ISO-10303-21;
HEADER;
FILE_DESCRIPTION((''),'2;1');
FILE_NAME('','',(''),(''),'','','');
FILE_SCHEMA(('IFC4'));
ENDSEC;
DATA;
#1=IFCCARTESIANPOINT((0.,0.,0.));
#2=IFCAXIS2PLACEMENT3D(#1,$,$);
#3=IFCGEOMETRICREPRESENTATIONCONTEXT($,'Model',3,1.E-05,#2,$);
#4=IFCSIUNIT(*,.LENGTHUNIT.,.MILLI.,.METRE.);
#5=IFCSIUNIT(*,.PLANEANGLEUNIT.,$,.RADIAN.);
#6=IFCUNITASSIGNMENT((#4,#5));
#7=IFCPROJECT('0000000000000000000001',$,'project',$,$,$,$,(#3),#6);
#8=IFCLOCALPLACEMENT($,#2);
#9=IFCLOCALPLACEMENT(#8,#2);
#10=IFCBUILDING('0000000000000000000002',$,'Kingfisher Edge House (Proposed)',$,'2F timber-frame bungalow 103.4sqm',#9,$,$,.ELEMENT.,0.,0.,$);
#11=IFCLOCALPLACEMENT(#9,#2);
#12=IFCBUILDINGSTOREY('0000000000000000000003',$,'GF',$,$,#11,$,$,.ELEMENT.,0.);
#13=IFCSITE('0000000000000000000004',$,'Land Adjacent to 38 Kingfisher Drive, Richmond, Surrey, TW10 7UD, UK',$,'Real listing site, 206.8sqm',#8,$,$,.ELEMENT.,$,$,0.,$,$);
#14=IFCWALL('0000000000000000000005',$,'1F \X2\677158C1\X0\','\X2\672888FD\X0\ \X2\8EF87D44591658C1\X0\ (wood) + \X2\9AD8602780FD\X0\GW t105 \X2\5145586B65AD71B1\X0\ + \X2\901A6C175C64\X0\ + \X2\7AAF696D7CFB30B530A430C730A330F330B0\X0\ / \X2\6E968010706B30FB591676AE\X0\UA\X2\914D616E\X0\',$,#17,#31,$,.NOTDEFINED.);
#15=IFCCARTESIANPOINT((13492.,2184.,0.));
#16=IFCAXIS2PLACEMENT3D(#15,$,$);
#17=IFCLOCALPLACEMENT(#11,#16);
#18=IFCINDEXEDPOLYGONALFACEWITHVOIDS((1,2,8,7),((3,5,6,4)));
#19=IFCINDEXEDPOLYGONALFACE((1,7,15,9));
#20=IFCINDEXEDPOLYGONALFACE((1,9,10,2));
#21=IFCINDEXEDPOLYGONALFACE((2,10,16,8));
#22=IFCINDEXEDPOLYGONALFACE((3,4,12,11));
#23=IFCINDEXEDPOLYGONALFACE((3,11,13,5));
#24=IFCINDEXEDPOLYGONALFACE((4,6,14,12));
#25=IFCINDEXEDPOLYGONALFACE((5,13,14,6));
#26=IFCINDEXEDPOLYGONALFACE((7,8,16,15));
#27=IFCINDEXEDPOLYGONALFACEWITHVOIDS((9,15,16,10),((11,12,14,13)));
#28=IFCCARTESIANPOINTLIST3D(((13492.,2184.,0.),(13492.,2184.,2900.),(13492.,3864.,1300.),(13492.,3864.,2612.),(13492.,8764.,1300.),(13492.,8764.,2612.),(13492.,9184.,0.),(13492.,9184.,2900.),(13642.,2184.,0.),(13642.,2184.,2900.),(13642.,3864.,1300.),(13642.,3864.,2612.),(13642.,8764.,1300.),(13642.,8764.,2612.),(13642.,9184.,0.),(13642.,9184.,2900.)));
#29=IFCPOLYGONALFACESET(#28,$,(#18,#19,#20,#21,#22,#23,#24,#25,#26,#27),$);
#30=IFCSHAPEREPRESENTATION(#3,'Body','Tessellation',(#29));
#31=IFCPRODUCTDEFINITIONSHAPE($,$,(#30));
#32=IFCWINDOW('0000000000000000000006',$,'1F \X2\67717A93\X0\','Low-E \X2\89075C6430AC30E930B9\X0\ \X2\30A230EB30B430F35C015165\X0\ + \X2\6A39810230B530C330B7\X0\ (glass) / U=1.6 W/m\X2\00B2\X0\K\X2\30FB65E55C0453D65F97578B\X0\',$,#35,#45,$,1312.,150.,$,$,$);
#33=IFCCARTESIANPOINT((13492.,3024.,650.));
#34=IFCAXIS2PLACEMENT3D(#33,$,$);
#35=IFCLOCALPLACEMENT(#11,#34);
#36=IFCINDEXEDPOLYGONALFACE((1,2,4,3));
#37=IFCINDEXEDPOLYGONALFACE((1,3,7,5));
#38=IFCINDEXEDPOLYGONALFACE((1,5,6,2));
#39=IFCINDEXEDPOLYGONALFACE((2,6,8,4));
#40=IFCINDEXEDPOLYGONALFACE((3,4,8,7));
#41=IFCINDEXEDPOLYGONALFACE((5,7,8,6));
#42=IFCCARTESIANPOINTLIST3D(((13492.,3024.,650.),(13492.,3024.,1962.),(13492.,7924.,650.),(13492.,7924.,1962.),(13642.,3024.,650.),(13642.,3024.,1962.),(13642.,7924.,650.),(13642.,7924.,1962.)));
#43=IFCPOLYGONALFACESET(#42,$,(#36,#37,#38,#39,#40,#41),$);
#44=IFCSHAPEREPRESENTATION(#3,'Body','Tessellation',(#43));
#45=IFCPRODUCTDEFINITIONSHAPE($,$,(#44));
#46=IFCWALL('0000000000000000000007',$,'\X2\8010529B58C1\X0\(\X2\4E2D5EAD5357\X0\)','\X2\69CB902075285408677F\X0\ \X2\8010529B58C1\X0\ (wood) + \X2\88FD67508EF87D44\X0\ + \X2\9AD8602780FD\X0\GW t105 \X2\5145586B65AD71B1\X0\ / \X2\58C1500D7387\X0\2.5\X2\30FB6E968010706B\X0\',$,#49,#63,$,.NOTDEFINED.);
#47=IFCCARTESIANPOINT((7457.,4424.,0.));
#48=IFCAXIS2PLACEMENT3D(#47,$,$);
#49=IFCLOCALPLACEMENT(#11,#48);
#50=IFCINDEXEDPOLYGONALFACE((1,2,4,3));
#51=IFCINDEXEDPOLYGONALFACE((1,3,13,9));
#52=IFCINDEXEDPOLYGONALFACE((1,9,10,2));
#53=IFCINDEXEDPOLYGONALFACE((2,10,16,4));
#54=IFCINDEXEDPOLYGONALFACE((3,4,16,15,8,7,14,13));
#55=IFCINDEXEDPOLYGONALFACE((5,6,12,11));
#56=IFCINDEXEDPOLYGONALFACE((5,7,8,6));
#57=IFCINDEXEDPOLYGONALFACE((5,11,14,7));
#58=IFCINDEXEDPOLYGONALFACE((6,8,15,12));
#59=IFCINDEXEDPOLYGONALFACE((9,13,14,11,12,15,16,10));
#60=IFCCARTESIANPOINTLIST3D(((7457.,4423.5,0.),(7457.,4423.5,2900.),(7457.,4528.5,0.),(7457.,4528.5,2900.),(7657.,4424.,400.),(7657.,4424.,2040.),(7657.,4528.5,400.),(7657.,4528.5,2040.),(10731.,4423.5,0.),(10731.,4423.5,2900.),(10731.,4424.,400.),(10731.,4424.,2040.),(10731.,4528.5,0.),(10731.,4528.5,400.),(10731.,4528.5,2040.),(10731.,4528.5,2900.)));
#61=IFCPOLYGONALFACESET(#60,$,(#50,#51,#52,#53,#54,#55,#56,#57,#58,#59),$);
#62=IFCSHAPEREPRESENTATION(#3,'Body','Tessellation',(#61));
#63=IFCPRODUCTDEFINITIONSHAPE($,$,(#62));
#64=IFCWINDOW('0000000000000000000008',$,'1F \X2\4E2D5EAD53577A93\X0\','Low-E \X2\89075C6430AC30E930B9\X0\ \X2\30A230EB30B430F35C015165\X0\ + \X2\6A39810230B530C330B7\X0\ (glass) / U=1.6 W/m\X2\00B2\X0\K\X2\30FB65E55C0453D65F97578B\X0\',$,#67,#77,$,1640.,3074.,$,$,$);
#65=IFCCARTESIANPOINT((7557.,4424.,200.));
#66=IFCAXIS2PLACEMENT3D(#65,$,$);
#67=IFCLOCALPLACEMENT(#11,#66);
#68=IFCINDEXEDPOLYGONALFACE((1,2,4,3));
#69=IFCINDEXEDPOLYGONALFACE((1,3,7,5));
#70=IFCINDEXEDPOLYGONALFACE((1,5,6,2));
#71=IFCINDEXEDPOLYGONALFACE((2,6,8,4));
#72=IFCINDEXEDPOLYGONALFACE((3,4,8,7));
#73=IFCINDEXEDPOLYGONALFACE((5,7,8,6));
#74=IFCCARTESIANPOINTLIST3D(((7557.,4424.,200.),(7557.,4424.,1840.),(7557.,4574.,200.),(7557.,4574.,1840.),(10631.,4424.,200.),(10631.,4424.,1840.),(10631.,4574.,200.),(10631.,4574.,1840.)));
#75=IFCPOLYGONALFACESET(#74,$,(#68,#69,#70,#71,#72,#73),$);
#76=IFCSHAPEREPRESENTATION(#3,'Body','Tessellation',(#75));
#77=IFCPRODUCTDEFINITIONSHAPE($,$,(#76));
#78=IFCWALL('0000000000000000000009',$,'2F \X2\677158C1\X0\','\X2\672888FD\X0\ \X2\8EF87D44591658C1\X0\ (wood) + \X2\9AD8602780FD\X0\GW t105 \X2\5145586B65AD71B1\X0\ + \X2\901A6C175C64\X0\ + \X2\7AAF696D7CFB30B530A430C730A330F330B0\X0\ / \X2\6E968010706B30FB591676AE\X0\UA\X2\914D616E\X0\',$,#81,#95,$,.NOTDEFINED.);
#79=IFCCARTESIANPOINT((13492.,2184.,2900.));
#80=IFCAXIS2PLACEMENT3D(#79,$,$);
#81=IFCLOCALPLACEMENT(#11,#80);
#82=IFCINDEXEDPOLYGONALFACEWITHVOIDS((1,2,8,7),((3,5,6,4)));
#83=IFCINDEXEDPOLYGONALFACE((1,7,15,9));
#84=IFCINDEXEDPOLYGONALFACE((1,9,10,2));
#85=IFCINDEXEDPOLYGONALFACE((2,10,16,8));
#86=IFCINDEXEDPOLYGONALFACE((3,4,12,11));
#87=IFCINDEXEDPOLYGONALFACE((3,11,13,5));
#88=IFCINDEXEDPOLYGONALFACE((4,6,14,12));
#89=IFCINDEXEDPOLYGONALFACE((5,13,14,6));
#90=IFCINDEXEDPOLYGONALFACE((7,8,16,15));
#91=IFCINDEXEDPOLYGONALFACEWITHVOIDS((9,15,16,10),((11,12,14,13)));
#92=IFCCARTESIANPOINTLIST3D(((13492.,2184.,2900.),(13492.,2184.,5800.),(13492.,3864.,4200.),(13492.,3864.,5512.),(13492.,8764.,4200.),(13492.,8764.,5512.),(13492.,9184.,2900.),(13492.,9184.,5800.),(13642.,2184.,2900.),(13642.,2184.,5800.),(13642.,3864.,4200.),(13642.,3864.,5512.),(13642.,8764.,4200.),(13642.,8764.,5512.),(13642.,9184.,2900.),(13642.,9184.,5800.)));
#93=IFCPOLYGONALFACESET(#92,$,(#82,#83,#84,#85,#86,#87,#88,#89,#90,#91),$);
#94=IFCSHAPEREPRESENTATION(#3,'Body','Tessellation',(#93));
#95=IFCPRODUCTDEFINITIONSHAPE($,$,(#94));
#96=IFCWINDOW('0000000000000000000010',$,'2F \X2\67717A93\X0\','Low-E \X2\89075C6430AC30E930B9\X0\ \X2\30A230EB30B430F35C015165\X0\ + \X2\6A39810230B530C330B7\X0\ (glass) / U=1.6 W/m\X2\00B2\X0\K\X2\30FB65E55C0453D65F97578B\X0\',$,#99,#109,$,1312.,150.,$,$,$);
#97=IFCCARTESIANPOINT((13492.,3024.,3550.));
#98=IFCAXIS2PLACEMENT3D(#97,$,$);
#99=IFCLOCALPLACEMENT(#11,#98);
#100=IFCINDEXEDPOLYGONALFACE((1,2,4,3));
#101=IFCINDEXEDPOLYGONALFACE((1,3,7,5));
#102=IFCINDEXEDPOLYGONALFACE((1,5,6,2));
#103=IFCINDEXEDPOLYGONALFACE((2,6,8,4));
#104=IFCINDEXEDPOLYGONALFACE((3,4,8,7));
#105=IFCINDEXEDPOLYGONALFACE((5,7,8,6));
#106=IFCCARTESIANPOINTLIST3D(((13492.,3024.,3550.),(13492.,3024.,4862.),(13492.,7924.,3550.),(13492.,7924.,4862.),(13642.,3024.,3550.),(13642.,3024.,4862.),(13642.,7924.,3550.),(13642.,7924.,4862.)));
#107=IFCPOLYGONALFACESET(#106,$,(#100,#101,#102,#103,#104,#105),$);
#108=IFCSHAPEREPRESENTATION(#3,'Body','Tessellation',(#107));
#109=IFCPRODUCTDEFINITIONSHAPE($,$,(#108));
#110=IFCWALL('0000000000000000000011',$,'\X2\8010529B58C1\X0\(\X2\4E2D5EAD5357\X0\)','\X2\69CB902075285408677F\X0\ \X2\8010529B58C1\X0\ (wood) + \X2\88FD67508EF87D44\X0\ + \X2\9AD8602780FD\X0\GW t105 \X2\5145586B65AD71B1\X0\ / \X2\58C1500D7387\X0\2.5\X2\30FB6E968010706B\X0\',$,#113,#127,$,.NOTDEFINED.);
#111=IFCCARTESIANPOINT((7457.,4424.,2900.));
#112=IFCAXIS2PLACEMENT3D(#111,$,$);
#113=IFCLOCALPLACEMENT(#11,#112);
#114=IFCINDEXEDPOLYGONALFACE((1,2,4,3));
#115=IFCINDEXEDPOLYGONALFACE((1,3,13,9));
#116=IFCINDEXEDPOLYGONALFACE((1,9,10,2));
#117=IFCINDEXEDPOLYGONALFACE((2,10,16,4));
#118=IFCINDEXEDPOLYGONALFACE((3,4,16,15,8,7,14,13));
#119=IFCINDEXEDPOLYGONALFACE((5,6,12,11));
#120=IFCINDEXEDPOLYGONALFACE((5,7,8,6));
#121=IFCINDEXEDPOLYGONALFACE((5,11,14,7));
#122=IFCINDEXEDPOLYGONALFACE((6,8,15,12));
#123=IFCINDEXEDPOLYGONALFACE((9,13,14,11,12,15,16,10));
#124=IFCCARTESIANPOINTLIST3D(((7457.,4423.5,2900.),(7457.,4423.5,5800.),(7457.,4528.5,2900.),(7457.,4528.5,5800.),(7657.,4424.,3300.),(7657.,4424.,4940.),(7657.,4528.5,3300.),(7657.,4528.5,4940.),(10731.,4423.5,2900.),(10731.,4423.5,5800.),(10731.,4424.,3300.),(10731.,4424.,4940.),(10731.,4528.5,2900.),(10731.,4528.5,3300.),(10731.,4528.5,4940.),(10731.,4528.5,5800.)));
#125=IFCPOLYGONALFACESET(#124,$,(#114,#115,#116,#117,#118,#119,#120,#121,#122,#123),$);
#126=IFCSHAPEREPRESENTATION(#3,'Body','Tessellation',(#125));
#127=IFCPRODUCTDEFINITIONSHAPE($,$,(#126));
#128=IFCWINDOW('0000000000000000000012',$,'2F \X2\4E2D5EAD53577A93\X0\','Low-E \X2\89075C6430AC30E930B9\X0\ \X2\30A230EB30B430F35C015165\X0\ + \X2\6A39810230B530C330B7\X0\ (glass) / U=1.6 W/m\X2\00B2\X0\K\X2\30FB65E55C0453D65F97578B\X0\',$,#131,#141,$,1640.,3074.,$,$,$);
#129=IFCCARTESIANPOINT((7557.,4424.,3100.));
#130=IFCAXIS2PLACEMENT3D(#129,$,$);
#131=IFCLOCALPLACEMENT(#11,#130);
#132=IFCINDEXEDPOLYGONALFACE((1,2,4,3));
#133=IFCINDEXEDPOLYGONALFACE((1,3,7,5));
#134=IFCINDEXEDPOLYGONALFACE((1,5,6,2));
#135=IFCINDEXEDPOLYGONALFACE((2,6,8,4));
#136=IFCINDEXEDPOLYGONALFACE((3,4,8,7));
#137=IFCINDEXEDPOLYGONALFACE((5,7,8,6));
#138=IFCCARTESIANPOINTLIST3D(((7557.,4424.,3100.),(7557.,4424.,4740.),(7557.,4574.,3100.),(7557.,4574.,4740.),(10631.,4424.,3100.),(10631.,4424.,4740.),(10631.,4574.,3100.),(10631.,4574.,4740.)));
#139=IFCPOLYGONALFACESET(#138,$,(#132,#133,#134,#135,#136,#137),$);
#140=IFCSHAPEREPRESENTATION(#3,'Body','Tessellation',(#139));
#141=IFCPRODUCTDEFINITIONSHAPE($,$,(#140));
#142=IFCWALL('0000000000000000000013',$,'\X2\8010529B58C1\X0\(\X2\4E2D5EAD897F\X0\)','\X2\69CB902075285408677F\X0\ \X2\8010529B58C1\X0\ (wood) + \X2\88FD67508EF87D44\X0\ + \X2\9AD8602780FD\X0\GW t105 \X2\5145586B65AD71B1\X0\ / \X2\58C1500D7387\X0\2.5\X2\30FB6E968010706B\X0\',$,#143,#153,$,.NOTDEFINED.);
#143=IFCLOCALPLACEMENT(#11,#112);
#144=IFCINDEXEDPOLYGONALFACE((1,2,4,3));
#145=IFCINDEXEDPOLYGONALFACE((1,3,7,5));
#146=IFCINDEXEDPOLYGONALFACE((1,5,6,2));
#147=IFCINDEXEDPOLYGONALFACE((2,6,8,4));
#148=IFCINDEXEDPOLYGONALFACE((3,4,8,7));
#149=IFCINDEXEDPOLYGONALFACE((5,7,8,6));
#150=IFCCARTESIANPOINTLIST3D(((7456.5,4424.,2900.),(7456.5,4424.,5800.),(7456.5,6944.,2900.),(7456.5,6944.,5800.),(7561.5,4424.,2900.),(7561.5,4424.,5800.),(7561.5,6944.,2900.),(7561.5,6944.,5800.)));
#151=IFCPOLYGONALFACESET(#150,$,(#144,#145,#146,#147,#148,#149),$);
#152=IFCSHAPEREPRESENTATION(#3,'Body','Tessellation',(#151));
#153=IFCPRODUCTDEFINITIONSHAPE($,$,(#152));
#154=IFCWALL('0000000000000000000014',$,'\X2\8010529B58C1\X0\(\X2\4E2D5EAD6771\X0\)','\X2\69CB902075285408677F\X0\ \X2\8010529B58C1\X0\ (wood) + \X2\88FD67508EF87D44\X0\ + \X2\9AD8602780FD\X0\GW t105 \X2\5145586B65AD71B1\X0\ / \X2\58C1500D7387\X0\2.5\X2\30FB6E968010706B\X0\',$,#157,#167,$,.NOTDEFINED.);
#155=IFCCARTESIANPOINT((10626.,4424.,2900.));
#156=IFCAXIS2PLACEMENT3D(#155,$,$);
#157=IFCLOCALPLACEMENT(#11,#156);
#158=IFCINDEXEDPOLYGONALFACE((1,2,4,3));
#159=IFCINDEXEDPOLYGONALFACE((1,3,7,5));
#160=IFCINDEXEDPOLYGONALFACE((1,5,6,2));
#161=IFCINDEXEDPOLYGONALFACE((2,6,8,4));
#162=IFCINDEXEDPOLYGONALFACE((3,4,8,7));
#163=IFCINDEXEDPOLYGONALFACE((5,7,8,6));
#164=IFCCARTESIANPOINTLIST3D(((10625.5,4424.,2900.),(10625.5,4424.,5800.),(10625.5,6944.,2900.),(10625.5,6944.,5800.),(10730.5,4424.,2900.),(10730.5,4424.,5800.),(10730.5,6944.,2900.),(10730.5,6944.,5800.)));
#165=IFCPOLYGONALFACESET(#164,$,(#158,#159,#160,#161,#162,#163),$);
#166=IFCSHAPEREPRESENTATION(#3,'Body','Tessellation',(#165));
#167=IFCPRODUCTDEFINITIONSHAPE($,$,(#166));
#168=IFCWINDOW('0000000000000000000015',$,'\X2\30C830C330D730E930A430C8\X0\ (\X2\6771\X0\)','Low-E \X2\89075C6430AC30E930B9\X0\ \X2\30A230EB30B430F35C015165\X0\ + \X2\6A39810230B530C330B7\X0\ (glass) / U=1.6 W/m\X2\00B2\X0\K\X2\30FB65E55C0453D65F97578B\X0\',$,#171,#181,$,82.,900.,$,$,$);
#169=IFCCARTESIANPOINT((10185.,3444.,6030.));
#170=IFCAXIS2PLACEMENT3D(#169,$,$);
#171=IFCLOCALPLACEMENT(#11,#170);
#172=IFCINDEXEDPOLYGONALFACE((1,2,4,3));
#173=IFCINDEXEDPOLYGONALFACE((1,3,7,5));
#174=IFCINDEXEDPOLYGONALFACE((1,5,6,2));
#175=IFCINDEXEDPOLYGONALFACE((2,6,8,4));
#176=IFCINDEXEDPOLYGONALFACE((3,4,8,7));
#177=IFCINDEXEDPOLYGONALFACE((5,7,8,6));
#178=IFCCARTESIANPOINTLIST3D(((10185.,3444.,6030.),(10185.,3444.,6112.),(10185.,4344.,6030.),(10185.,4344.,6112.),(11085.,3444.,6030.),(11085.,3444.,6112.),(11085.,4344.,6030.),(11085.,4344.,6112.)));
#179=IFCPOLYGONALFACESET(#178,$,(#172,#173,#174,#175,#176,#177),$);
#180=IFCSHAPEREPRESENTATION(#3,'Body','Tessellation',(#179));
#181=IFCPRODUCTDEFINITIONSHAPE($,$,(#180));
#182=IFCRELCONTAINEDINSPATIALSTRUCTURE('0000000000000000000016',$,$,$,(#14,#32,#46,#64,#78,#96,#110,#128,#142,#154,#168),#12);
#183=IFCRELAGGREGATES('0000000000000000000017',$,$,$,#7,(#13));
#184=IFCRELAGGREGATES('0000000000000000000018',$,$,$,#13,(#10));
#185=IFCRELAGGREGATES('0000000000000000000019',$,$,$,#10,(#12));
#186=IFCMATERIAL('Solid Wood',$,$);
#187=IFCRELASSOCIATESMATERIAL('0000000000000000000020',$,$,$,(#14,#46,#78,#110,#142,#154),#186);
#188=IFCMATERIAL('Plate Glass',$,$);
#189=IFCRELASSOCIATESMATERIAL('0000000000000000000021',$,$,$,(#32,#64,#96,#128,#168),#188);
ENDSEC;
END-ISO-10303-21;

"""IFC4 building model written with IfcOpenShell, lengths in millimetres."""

from ifc_helpers import new_model, si_unit, frame, frame_2d, origin, place, context, project, spatial, rectangle, extrude, material, element, fill, save


model = new_model("IFC4")

# Units and contexts
model_context = context("Model", 3, precision=1e-05, world=origin())
ifc_project = project(units=[si_unit("LENGTHUNIT", "METRE", prefix="MILLI"), si_unit("PLANEANGLEUNIT", "RADIAN")], contexts=[model_context])

# Site, building, storey
site_placement = place(None, origin())
site = spatial("IfcSite", under=ifc_project, at=site_placement, Name="Land Adjacent to 38 Kingfisher Drive, Richmond, Surrey, TW10 7UD, UK", ObjectType="Real listing site, 206.8sqm", CompositionType="ELEMENT", RefElevation=0.0)
building_placement = place(site_placement, origin())
building = spatial("IfcBuilding", under=site, at=building_placement, Name="Kingfisher Edge House (Proposed)", ObjectType="2F timber-frame bungalow 103.4sqm", CompositionType="ELEMENT", ElevationOfRefHeight=0.0, ElevationOfTerrain=0.0)
storey_placement = place(building_placement, origin())
storey = spatial("IfcBuildingStorey", under=building, at=storey_placement, Name="GF", CompositionType="ELEMENT", Elevation=0.0)

# Shared definitions
ifc_material_1 = material(Name="Solid Wood")

# Walls, openings, windows
wall_1_placement = place(storey_placement, frame((13492.0, 2184.0, 0.0)))
wall_1 = element("IfcWall", 1, at=wall_1_placement, inside=storey, material=ifc_material_1, Name="1F 東壁", Description="木製 軸組外壁 (wood) + 高性能GW t105 充填断熱 + 通気層 + 窯業系サイディング / 準耐火・外皮UA配慮", PredefinedType="NOTDEFINED", context=model_context, shape_type="SweptSolid", body=[
    extrude(rectangle(XDim=150.0, YDim=7000.0, at=frame_2d((75.0, 3500.0))), frame((13492.0, 2184.0, 0.0)), (0.0, 0.0, 1.0), 2900.0),
])
opening_1_placement = place(storey_placement, frame((13492.0, 3024.0, 650.0)))
opening_1 = element("IfcOpeningElement", 2, at=opening_1_placement, cuts=wall_1, PredefinedType="NOTDEFINED", context=model_context, shape_type="SweptSolid", body=[
    extrude(rectangle(XDim=150.0, YDim=4900.0, at=frame_2d((75.0, 2450.0))), frame((13492.0, 3024.0, 650.0)), (0.0, 0.0, 1.0), 1312.0),
])
ifc_material_2 = material(Name="Plate Glass")
window_1_placement = place(storey_placement, frame((13492.0, 3024.0, 650.0)))
window_1 = element("IfcWindow", 3, at=window_1_placement, inside=storey, material=ifc_material_2, Name="1F 東窓", Description="Low-E 複層ガラス アルゴン封入 + 樹脂サッシ (glass) / U=1.6 W/m²K・日射取得型", OverallHeight=1312.0, OverallWidth=150.0, context=model_context, shape_type="SweptSolid", body=[
    extrude(rectangle(XDim=150.0, YDim=4900.0, at=frame_2d((75.0, 2450.0))), frame((13492.0, 3024.0, 650.0)), (0.0, 0.0, 1.0), 1312.0),
])
fill(opening_1, window_1)
wall_2_placement = place(storey_placement, frame((7457.0, 4424.0, 0.0)))
wall_2 = element("IfcWall", 4, at=wall_2_placement, inside=storey, material=ifc_material_1, Name="耐力壁(中庭南)", Description="構造用合板 耐力壁 (wood) + 製材軸組 + 高性能GW t105 充填断熱 / 壁倍率2.5・準耐火", PredefinedType="NOTDEFINED", context=model_context, shape_type="SweptSolid", body=[
    extrude(rectangle(XDim=3274.0, YDim=105.0, at=frame_2d((1637.0, 52.0))), frame((7457.0, 4424.0, 0.0)), (0.0, 0.0, 1.0), 2900.0),
])
opening_2_placement = place(storey_placement, frame((7557.0, 4424.0, 200.0)))
opening_2 = element("IfcOpeningElement", 5, at=opening_2_placement, cuts=wall_2, PredefinedType="NOTDEFINED", context=model_context, shape_type="SweptSolid", body=[
    extrude(rectangle(XDim=3074.0, YDim=150.0, at=frame_2d((1537.0, 75.0))), frame((7557.0, 4424.0, 200.0)), (0.0, 0.0, 1.0), 1640.0),
])
window_2_placement = place(storey_placement, frame((7557.0, 4424.0, 200.0)))
window_2 = element("IfcWindow", 6, at=window_2_placement, inside=storey, material=ifc_material_2, Name="1F 中庭南窓", Description="Low-E 複層ガラス アルゴン封入 + 樹脂サッシ (glass) / U=1.6 W/m²K・日射取得型", OverallHeight=1640.0, OverallWidth=3074.0, context=model_context, shape_type="SweptSolid", body=[
    extrude(rectangle(XDim=3074.0, YDim=150.0, at=frame_2d((1537.0, 75.0))), frame((7557.0, 4424.0, 200.0)), (0.0, 0.0, 1.0), 1640.0),
])
fill(opening_2, window_2)

# Walls, openings, windows
wall_3_placement = place(storey_placement, frame((13492.0, 2184.0, 2900.0)))
wall_3 = element("IfcWall", 7, at=wall_3_placement, inside=storey, material=ifc_material_1, Name="2F 東壁", Description="木製 軸組外壁 (wood) + 高性能GW t105 充填断熱 + 通気層 + 窯業系サイディング / 準耐火・外皮UA配慮", PredefinedType="NOTDEFINED", context=model_context, shape_type="SweptSolid", body=[
    extrude(rectangle(XDim=150.0, YDim=7000.0, at=frame_2d((75.0, 3500.0))), frame((13492.0, 2184.0, 2900.0)), (0.0, 0.0, 1.0), 2900.0),
])
opening_3_placement = place(storey_placement, frame((13492.0, 3024.0, 3550.0)))
opening_3 = element("IfcOpeningElement", 8, at=opening_3_placement, cuts=wall_3, PredefinedType="NOTDEFINED", context=model_context, shape_type="SweptSolid", body=[
    extrude(rectangle(XDim=150.0, YDim=4900.0, at=frame_2d((75.0, 2450.0))), frame((13492.0, 3024.0, 3550.0)), (0.0, 0.0, 1.0), 1312.0),
])
window_3_placement = place(storey_placement, frame((13492.0, 3024.0, 3550.0)))
window_3 = element("IfcWindow", 9, at=window_3_placement, inside=storey, material=ifc_material_2, Name="2F 東窓", Description="Low-E 複層ガラス アルゴン封入 + 樹脂サッシ (glass) / U=1.6 W/m²K・日射取得型", OverallHeight=1312.0, OverallWidth=150.0, context=model_context, shape_type="SweptSolid", body=[
    extrude(rectangle(XDim=150.0, YDim=4900.0, at=frame_2d((75.0, 2450.0))), frame((13492.0, 3024.0, 3550.0)), (0.0, 0.0, 1.0), 1312.0),
])
fill(opening_3, window_3)
wall_4_placement = place(storey_placement, frame((7457.0, 4424.0, 2900.0)))
wall_4 = element("IfcWall", 10, at=wall_4_placement, inside=storey, material=ifc_material_1, Name="耐力壁(中庭南)", Description="構造用合板 耐力壁 (wood) + 製材軸組 + 高性能GW t105 充填断熱 / 壁倍率2.5・準耐火", PredefinedType="NOTDEFINED", context=model_context, shape_type="SweptSolid", body=[
    extrude(rectangle(XDim=3274.0, YDim=105.0, at=frame_2d((1637.0, 52.0))), frame((7457.0, 4424.0, 2900.0)), (0.0, 0.0, 1.0), 2900.0),
])
opening_4_placement = place(storey_placement, frame((7557.0, 4424.0, 3100.0)))
opening_4 = element("IfcOpeningElement", 11, at=opening_4_placement, cuts=wall_4, PredefinedType="NOTDEFINED", context=model_context, shape_type="SweptSolid", body=[
    extrude(rectangle(XDim=3074.0, YDim=150.0, at=frame_2d((1537.0, 75.0))), frame((7557.0, 4424.0, 3100.0)), (0.0, 0.0, 1.0), 1640.0),
])
window_4_placement = place(storey_placement, frame((7557.0, 4424.0, 3100.0)))
window_4 = element("IfcWindow", 12, at=window_4_placement, inside=storey, material=ifc_material_2, Name="2F 中庭南窓", Description="Low-E 複層ガラス アルゴン封入 + 樹脂サッシ (glass) / U=1.6 W/m²K・日射取得型", OverallHeight=1640.0, OverallWidth=3074.0, context=model_context, shape_type="SweptSolid", body=[
    extrude(rectangle(XDim=3074.0, YDim=150.0, at=frame_2d((1537.0, 75.0))), frame((7557.0, 4424.0, 3100.0)), (0.0, 0.0, 1.0), 1640.0),
])
fill(opening_4, window_4)

# Walls
wall_5_placement = place(storey_placement, frame((7457.0, 4424.0, 2900.0)))
element("IfcWall", 13, at=wall_5_placement, inside=storey, material=ifc_material_1, Name="耐力壁(中庭西)", Description="構造用合板 耐力壁 (wood) + 製材軸組 + 高性能GW t105 充填断熱 / 壁倍率2.5・準耐火", PredefinedType="NOTDEFINED", context=model_context, shape_type="SweptSolid", body=[
    extrude(rectangle(XDim=105.0, YDim=2520.0, at=frame_2d((52.0, 1260.0))), frame((7457.0, 4424.0, 2900.0)), (0.0, 0.0, 1.0), 2900.0),
])
wall_6_placement = place(storey_placement, frame((10626.0, 4424.0, 2900.0)))
element("IfcWall", 14, at=wall_6_placement, inside=storey, material=ifc_material_1, Name="耐力壁(中庭東)", Description="構造用合板 耐力壁 (wood) + 製材軸組 + 高性能GW t105 充填断熱 / 壁倍率2.5・準耐火", PredefinedType="NOTDEFINED", context=model_context, shape_type="SweptSolid", body=[
    extrude(rectangle(XDim=105.0, YDim=2520.0, at=frame_2d((52.0, 1260.0))), frame((10626.0, 4424.0, 2900.0)), (0.0, 0.0, 1.0), 2900.0),
])

# Window
window_5_placement = place(storey_placement, frame((10185.0, 3444.0, 6030.0)))
element("IfcWindow", 15, at=window_5_placement, inside=storey, material=ifc_material_2, Name="トップライト (東)", Description="Low-E 複層ガラス アルゴン封入 + 樹脂サッシ (glass) / U=1.6 W/m²K・日射取得型", OverallHeight=82.0, OverallWidth=900.0, context=model_context, shape_type="SweptSolid", body=[
    extrude(rectangle(XDim=900.0, YDim=900.0, at=frame_2d((450.0, 450.0))), frame((10185.0, 3444.0, 6030.0)), (0.0, 0.0, 1.0), 82.0),
])

save(model, "model.ifc")
